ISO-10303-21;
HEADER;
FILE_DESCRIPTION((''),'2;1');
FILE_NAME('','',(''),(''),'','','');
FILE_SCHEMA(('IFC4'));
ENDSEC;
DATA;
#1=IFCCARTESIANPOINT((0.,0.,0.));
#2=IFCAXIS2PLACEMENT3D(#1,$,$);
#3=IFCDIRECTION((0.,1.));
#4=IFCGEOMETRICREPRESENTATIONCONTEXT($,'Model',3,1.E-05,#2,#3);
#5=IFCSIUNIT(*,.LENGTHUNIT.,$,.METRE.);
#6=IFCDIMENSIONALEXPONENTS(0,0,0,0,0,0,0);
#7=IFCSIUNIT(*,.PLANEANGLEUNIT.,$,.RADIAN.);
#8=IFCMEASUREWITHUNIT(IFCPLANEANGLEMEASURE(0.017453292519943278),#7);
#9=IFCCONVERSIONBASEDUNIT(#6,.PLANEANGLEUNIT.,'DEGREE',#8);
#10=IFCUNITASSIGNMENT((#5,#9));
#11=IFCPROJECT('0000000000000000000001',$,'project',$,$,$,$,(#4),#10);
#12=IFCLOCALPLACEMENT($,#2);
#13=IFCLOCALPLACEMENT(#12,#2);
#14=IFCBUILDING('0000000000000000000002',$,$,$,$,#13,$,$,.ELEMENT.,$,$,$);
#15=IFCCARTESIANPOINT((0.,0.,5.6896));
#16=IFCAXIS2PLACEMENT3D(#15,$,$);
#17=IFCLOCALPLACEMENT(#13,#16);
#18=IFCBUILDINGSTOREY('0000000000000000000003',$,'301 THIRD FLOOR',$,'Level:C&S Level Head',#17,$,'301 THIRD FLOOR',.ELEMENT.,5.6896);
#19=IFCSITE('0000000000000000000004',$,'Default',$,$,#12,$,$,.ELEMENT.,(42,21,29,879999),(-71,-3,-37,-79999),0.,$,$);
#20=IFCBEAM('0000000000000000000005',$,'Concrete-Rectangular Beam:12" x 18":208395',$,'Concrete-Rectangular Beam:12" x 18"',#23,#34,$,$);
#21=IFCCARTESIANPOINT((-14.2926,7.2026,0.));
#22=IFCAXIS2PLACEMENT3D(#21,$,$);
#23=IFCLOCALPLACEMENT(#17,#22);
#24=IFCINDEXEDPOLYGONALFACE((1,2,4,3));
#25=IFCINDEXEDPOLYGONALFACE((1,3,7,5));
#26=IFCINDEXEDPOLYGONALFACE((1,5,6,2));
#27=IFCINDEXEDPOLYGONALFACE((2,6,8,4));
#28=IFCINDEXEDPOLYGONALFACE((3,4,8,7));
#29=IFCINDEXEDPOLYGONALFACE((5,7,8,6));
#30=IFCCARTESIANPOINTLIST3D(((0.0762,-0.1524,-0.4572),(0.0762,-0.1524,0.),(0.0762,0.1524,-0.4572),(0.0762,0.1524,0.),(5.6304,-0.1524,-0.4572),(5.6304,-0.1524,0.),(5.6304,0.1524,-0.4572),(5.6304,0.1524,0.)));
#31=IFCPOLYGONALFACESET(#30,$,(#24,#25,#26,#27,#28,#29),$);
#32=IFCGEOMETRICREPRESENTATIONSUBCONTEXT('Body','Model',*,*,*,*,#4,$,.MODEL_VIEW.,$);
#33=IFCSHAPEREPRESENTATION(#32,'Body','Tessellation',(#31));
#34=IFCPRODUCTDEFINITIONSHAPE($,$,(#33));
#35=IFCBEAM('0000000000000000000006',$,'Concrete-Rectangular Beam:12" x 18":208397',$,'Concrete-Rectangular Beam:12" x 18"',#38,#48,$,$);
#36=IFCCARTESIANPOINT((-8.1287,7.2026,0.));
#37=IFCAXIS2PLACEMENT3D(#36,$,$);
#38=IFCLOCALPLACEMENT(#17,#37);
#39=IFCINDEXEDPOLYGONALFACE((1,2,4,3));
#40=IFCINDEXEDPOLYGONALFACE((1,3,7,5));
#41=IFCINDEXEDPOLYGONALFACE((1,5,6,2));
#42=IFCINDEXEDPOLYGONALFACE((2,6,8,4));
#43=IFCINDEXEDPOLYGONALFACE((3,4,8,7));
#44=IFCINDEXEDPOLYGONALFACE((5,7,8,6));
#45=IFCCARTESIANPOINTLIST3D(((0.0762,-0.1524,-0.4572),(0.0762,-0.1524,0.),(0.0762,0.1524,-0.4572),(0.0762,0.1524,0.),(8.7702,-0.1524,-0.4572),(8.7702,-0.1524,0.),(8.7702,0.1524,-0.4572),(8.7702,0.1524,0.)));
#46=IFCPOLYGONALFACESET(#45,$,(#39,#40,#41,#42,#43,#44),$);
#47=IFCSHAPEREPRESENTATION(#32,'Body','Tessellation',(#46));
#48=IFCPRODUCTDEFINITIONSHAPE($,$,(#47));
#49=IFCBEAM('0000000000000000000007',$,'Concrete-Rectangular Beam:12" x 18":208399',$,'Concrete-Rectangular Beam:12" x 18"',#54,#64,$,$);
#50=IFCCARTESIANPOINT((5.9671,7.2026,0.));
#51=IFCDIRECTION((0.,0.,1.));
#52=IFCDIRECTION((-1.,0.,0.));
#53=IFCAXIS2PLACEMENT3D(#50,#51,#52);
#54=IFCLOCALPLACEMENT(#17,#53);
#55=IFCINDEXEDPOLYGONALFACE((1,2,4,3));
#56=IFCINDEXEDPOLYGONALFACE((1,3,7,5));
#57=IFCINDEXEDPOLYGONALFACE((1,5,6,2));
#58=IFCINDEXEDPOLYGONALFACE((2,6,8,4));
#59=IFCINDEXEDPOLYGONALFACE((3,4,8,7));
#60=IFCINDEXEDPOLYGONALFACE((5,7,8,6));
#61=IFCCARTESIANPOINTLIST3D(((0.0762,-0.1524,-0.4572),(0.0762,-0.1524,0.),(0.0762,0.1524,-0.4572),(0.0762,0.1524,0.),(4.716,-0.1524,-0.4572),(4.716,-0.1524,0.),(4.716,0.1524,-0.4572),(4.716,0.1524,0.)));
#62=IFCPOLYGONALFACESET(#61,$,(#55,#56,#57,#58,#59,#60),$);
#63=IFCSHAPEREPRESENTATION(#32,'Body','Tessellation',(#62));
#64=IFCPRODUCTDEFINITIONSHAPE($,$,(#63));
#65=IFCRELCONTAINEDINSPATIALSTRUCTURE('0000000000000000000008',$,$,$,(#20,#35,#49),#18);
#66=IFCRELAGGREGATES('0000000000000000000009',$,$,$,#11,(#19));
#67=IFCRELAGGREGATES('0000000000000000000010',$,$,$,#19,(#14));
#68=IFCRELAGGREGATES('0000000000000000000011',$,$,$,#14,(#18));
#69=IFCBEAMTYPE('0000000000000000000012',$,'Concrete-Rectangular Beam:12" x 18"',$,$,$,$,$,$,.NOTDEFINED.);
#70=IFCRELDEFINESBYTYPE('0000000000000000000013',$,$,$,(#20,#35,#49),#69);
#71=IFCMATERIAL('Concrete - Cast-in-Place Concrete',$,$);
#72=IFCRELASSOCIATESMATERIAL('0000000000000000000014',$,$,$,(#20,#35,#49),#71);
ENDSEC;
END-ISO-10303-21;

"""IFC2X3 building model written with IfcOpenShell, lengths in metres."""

from ifc_helpers import new_model, entity, si_unit, converted_unit, direction, frame, frame_2d, origin, place, context, subcontext, project, spatial, rectangle, extrude, material, type_object, element, save


model = new_model("IFC2X3")

# Units and contexts
model_context = context("Model", 3, precision=1e-05, world=origin(), true_north=direction((0.0, 1.0)))
body_context = subcontext(model_context, "Body", "Model", "MODEL_VIEW")
ifc_project = project(units=[si_unit("LENGTHUNIT", "METRE"), converted_unit("PLANEANGLEUNIT", "DEGREE", entity("IfcPlaneAngleMeasure", 0.017453292519943278), si_unit("PLANEANGLEUNIT", "RADIAN"), dimensions=[0, 0, 0, 0, 0, 0, 0])], contexts=[model_context])

# Site, building, storey
site_placement = place(None, origin())
site = spatial("IfcSite", under=ifc_project, at=site_placement, Name="Default", CompositionType="ELEMENT", RefLatitude=(42, 21, 29, 879999), RefLongitude=(-71, -3, -37, -79999), RefElevation=0.0)
building_placement = place(site_placement, origin())
building = spatial("IfcBuilding", under=site, at=building_placement, CompositionType="ELEMENT")
storey_placement = place(building_placement, frame((0.0, 0.0, 5.6896)))
storey = spatial("IfcBuildingStorey", under=building, at=storey_placement, Name="301 THIRD FLOOR", ObjectType="Level:C&S Level Head", LongName="301 THIRD FLOOR", CompositionType="ELEMENT", Elevation=5.6896)

# Shared definitions
ifc_material_1 = material(Name="Concrete - Cast-in-Place Concrete")

# Beams
beam_type = type_object("IfcBeamType", Name="Concrete-Rectangular Beam:12\" x 18\"", PredefinedType="NOTDEFINED")
beam_1_placement = place(storey_placement, frame((-14.2926, 7.2026, 0.0)))
element("IfcBeam", 1, at=beam_1_placement, inside=storey, type_object=beam_type, material=ifc_material_1, Name="Concrete-Rectangular Beam:12\" x 18\":208395", ObjectType="Concrete-Rectangular Beam:12\" x 18\"", context=body_context, shape_type="SweptSolid", body=[
    extrude(rectangle(XDim=0.4572, YDim=0.3048, at=frame_2d((0.0, 0.0), x_axis=(1.0, 0.0))), frame((0.0762, 0.0, -0.2286), z_axis=(1.0, 0.0, 0.0), x_axis=(0.0, 0.0, -1.0)), (0.0, 0.0, 1.0), 5.5542),
])
beam_2_placement = place(storey_placement, frame((-8.1287, 7.2026, 0.0)))
element("IfcBeam", 2, at=beam_2_placement, inside=storey, type_object=beam_type, material=ifc_material_1, Name="Concrete-Rectangular Beam:12\" x 18\":208397", ObjectType="Concrete-Rectangular Beam:12\" x 18\"", context=body_context, shape_type="SweptSolid", body=[
    extrude(rectangle(XDim=0.4572, YDim=0.3048, at=frame_2d((0.0, 0.0), x_axis=(1.0, 0.0))), frame((0.0762, 0.0, -0.2286), z_axis=(1.0, 0.0, 0.0), x_axis=(0.0, 0.0, -1.0)), (0.0, 0.0, 1.0), 8.694),
])
beam_3_placement = place(storey_placement, frame((5.9671, 7.2026, 0.0), z_axis=(0.0, 0.0, 1.0), x_axis=(-1.0, 0.0, 0.0)))
element("IfcBeam", 3, at=beam_3_placement, inside=storey, type_object=beam_type, material=ifc_material_1, Name="Concrete-Rectangular Beam:12\" x 18\":208399", ObjectType="Concrete-Rectangular Beam:12\" x 18\"", context=body_context, shape_type="SweptSolid", body=[
    extrude(rectangle(XDim=0.4572, YDim=0.3048, at=frame_2d((0.0, 0.0), x_axis=(1.0, 0.0))), frame((0.0762, 0.0, -0.2286), z_axis=(1.0, 0.0, 0.0), x_axis=(0.0, 0.0, -1.0)), (0.0, 0.0, 1.0), 4.6398),
])

save(model, "model.ifc")
